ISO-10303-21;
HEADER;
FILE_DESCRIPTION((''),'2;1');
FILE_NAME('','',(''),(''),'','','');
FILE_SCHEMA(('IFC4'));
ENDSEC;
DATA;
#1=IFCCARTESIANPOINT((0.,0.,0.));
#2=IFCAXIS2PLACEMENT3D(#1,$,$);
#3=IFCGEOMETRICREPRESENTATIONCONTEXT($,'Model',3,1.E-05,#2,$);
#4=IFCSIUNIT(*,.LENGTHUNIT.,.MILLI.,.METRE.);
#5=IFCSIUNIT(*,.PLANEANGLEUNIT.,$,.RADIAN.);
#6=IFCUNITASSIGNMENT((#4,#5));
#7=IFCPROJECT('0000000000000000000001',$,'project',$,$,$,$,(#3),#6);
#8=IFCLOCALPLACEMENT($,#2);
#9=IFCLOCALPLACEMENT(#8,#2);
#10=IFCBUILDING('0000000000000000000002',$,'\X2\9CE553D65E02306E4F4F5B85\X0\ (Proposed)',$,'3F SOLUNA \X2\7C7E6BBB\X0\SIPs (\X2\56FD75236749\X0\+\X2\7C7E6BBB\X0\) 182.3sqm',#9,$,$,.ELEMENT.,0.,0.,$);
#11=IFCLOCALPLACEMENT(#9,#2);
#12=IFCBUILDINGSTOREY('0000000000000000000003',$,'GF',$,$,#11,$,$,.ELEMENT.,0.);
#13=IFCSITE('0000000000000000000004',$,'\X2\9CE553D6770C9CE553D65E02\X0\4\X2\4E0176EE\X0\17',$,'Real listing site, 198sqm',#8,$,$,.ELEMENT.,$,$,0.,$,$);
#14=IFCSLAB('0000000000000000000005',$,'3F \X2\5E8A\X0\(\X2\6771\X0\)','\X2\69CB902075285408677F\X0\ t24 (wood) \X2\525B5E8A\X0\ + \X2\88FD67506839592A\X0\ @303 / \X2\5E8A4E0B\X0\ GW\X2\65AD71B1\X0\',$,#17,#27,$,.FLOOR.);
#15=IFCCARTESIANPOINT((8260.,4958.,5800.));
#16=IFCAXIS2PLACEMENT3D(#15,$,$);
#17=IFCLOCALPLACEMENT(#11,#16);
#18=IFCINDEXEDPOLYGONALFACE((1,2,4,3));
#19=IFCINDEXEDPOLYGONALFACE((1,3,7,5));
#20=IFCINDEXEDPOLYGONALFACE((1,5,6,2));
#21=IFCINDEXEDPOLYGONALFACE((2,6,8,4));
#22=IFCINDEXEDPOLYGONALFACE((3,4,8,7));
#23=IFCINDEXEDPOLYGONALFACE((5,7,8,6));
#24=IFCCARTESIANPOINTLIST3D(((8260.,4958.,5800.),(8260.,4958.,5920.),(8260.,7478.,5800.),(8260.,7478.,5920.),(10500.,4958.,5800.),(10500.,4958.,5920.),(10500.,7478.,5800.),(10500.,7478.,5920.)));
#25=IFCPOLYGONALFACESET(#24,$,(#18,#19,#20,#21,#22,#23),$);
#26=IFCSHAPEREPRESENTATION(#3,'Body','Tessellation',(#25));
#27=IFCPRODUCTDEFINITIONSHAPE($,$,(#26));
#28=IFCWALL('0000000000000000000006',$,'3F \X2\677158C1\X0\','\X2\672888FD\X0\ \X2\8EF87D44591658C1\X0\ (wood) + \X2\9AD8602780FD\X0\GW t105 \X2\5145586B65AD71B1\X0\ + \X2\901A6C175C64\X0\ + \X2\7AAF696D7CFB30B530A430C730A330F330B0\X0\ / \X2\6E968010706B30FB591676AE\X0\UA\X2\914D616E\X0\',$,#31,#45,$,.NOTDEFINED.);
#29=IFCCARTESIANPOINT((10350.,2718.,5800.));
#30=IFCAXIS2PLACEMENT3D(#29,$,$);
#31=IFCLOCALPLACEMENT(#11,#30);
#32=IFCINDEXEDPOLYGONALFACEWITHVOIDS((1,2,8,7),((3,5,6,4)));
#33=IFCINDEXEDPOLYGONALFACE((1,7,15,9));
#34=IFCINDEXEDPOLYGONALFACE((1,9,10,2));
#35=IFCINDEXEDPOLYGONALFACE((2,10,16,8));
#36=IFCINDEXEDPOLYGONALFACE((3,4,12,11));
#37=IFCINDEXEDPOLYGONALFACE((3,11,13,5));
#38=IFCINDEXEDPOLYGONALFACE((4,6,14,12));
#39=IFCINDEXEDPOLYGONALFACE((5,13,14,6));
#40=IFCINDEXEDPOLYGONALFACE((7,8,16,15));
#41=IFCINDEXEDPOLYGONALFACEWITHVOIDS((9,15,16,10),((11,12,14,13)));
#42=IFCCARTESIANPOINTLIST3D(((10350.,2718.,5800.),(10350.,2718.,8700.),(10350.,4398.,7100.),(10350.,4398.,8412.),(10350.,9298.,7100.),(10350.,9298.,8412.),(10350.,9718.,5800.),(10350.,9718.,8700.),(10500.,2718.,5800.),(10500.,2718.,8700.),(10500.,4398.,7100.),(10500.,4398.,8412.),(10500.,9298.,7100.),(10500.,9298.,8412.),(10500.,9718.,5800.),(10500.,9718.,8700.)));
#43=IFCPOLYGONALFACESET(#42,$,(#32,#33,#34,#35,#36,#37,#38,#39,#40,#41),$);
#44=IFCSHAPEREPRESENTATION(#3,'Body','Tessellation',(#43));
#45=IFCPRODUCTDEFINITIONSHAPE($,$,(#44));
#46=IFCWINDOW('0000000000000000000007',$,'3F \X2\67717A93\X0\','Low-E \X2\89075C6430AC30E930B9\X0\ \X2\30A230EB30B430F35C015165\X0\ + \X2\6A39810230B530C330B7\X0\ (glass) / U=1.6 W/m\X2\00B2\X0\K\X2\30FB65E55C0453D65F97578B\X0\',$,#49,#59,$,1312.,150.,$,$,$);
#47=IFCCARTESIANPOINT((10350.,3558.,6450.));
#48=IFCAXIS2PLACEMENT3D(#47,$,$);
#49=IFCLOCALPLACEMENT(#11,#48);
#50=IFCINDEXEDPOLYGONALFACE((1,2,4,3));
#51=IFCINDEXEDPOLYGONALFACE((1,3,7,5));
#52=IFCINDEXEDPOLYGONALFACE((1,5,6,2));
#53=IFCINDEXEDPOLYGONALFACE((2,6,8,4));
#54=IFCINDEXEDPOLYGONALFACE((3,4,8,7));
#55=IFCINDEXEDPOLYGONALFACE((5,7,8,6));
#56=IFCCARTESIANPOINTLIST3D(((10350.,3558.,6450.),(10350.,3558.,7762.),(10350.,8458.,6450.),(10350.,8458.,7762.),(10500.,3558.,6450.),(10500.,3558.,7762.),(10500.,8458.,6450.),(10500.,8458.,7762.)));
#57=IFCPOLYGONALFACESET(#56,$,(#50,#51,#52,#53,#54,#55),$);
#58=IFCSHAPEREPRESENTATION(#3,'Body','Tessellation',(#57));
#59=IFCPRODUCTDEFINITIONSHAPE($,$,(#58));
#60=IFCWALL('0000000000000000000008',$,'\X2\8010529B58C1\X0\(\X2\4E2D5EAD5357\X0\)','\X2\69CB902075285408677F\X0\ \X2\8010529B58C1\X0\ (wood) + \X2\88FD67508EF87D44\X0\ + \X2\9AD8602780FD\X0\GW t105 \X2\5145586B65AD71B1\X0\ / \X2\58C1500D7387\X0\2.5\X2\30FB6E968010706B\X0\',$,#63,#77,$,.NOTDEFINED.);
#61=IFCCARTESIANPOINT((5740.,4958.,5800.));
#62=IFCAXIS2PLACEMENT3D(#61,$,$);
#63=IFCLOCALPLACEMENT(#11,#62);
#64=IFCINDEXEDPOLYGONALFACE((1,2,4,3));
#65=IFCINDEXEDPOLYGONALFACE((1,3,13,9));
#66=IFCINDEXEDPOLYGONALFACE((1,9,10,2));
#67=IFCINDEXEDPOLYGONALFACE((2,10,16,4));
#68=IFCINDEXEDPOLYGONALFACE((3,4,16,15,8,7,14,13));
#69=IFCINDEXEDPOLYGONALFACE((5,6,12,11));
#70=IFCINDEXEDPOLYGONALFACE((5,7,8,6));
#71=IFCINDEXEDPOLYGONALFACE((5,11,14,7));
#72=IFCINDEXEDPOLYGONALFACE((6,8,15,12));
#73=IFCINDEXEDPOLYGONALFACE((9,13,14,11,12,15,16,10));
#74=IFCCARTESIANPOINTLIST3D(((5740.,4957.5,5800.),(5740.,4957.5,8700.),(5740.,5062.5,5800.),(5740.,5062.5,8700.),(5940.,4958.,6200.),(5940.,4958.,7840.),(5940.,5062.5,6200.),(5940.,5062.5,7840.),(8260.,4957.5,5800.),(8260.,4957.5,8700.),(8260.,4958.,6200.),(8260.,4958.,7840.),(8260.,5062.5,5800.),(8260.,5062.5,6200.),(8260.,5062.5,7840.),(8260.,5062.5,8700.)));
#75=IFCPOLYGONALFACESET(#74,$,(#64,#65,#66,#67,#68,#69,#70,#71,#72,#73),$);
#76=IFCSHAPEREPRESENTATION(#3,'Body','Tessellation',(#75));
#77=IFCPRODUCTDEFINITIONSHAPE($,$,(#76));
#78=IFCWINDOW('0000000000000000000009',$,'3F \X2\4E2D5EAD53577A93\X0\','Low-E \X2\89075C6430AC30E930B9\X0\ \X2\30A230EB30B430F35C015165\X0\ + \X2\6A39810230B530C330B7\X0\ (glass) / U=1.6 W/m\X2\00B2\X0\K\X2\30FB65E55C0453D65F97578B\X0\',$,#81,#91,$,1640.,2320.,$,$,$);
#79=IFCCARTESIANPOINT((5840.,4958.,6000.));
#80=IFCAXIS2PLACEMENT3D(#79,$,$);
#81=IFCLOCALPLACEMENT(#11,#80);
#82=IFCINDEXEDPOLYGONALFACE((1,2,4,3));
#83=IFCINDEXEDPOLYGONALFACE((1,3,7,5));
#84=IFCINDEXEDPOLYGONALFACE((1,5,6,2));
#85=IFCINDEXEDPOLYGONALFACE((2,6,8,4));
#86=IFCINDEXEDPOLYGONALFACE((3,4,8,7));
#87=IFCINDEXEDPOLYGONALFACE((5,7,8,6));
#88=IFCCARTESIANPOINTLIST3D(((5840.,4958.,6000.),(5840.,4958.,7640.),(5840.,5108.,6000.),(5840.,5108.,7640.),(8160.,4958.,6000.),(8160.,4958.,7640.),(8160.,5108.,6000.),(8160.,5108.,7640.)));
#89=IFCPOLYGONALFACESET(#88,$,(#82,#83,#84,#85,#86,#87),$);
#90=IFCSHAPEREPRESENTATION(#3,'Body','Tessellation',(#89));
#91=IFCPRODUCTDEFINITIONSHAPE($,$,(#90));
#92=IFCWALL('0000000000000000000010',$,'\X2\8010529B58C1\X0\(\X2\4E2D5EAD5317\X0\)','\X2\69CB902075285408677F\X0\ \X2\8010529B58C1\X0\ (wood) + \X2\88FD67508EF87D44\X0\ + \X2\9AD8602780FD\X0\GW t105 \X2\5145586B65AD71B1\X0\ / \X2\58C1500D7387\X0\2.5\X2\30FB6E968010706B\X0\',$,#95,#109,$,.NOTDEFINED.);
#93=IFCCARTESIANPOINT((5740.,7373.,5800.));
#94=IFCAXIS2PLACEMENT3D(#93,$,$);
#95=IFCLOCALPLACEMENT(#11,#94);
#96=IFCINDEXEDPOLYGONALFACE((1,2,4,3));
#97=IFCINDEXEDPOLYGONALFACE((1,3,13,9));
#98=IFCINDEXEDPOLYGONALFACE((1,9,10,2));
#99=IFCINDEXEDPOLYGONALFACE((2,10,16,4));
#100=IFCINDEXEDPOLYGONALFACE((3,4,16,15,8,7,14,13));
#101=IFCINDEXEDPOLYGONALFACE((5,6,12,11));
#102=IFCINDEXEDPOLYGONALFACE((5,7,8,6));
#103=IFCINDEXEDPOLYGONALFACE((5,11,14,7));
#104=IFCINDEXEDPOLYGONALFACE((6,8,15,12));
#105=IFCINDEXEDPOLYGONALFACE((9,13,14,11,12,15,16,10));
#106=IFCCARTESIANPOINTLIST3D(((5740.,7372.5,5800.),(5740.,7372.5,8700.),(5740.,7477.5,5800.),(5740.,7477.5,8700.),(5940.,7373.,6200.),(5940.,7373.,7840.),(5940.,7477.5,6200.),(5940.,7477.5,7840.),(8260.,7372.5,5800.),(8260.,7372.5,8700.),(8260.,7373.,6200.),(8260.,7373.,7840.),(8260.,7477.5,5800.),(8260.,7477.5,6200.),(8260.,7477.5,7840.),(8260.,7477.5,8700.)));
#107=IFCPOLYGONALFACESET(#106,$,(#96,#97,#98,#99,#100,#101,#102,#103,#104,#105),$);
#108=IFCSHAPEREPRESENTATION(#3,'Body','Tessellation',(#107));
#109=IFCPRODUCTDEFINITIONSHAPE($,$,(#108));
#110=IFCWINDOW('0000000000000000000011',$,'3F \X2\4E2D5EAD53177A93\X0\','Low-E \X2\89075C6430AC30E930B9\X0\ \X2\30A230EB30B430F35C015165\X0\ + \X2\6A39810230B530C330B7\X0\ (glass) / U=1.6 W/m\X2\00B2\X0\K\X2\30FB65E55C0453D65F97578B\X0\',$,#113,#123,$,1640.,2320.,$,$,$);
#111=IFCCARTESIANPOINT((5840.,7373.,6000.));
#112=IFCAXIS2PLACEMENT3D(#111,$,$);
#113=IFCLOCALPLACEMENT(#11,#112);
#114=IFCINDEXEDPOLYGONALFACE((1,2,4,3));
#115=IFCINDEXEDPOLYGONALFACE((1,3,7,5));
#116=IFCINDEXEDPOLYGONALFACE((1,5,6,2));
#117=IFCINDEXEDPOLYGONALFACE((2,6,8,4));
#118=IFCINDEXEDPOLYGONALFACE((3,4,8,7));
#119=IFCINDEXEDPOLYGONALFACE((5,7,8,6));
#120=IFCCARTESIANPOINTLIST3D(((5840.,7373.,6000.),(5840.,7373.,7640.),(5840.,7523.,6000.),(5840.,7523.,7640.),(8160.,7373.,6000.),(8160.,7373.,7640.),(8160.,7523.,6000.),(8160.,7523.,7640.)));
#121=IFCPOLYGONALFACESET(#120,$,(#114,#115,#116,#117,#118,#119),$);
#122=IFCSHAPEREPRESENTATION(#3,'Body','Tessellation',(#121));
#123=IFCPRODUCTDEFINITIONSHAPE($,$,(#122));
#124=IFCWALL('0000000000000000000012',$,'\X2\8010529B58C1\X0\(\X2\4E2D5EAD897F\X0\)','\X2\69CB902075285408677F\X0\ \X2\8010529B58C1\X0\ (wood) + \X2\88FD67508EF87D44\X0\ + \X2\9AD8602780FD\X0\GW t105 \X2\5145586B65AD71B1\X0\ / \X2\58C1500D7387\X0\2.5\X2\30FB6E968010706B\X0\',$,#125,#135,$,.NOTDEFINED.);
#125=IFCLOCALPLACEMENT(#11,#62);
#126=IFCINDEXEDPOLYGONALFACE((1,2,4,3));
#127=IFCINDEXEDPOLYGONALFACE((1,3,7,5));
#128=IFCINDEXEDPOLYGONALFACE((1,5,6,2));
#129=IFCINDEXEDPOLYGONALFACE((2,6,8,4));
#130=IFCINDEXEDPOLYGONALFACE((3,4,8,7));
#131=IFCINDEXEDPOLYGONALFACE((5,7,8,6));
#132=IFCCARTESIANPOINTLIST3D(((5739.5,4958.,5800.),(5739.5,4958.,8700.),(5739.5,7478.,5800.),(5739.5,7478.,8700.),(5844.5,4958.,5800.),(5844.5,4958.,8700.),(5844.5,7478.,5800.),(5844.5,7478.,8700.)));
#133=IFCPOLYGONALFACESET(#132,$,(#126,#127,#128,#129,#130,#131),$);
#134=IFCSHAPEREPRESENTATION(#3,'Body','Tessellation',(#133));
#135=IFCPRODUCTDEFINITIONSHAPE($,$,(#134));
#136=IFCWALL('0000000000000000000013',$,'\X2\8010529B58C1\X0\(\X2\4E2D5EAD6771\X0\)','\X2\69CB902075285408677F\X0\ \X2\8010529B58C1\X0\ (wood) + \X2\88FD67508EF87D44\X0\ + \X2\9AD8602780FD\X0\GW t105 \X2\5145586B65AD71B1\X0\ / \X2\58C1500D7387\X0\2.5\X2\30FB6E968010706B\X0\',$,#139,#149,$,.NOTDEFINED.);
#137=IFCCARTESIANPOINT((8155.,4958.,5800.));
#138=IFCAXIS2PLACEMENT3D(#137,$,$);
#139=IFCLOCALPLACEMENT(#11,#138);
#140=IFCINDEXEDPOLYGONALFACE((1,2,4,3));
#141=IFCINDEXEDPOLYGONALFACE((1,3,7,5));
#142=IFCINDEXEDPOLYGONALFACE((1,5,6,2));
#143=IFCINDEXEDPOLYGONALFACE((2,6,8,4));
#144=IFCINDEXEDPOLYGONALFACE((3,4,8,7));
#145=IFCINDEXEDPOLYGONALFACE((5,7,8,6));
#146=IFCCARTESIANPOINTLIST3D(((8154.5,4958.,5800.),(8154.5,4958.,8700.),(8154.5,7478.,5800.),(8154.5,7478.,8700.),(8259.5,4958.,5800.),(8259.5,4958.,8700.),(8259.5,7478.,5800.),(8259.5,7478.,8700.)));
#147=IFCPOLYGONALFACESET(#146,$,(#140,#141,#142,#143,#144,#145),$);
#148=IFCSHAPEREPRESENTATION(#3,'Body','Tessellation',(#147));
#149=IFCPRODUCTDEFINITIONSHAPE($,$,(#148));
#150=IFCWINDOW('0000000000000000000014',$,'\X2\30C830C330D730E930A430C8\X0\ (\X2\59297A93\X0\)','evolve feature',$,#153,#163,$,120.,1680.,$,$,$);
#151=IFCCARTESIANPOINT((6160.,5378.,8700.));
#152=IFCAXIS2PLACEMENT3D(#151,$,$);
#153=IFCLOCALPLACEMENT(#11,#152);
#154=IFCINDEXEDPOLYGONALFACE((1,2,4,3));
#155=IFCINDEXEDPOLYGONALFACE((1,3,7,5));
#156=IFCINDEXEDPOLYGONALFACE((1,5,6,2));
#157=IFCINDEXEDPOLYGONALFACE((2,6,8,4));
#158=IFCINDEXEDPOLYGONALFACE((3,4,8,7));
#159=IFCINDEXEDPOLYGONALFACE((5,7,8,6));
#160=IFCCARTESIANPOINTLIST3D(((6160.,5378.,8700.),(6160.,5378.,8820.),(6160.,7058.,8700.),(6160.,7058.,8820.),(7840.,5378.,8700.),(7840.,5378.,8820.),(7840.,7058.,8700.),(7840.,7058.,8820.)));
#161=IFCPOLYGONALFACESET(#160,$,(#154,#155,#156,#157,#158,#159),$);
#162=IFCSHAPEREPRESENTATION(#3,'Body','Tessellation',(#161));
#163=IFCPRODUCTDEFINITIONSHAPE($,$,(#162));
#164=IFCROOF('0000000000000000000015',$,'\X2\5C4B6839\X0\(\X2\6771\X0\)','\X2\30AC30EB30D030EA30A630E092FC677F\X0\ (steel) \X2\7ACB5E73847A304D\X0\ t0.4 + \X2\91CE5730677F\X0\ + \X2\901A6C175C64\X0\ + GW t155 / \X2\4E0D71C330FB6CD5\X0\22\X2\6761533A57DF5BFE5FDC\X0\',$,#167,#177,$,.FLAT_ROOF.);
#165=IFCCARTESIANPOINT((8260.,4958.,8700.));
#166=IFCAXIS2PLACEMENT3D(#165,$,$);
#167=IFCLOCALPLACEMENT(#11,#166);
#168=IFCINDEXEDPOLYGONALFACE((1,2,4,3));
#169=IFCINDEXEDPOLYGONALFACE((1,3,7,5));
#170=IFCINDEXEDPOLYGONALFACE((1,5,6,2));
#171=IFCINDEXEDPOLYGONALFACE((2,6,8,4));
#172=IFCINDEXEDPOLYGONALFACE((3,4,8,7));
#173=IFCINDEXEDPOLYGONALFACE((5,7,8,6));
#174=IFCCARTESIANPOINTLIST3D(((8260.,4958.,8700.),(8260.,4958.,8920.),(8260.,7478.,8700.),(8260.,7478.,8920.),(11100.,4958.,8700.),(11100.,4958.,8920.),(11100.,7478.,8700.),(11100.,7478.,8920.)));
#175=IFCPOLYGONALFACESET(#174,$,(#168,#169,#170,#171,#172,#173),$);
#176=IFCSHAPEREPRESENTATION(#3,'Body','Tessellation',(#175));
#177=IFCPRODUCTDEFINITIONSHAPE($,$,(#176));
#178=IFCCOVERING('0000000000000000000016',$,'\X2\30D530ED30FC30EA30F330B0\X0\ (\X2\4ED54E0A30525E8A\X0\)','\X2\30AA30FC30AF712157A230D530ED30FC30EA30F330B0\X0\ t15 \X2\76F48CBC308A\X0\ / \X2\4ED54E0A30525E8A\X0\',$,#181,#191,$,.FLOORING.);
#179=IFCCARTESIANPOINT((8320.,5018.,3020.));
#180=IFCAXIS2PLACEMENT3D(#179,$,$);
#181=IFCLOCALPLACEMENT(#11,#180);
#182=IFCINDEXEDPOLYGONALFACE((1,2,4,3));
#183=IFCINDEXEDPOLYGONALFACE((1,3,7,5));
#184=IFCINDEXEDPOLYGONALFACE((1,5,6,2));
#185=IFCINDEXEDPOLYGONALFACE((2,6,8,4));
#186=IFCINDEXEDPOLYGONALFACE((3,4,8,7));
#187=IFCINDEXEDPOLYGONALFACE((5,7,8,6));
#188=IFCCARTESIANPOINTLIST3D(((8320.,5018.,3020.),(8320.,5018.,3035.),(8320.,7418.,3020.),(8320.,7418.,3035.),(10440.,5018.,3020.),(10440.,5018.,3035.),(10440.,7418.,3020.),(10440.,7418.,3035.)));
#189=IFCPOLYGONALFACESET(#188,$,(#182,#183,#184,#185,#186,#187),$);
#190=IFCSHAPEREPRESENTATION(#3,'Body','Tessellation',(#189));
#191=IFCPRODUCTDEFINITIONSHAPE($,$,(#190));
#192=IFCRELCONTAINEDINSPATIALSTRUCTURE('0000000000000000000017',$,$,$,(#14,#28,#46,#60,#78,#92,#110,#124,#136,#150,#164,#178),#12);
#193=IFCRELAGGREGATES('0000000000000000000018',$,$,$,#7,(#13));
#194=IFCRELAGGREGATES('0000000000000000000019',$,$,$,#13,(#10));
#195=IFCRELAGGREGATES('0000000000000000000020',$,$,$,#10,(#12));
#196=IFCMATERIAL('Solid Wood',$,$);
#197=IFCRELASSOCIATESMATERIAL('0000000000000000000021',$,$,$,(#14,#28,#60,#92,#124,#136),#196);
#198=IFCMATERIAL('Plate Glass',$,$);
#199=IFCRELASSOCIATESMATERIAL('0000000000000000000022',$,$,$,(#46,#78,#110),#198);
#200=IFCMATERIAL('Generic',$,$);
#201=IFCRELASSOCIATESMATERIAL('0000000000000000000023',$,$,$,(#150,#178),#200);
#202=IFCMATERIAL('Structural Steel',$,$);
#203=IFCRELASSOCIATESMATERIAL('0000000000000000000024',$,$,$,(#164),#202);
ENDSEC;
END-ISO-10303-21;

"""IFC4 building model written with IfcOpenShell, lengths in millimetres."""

from ifc_helpers import new_model, si_unit, frame, frame_2d, origin, place, context, project, spatial, rectangle, extrude, material, element, fill, save


model = new_model("IFC4")

# Units and contexts
model_context = context("Model", 3, precision=1e-05, world=origin())
ifc_project = project(units=[si_unit("LENGTHUNIT", "METRE", prefix="MILLI"), si_unit("PLANEANGLEUNIT", "RADIAN")], contexts=[model_context])

# Site, building, storey
site_placement = place(None, origin())
site = spatial("IfcSite", under=ifc_project, at=site_placement, Name="鳥取県鳥取市4丁目17", ObjectType="Real listing site, 198sqm", CompositionType="ELEMENT", RefElevation=0.0)
building_placement = place(site_placement, origin())
building = spatial("IfcBuilding", under=site, at=building_placement, Name="鳥取市の住宅 (Proposed)", ObjectType="3F SOLUNA 籾殻SIPs (国産杉+籾殻) 182.3sqm", CompositionType="ELEMENT", ElevationOfRefHeight=0.0, ElevationOfTerrain=0.0)
storey_placement = place(building_placement, origin())
storey = spatial("IfcBuildingStorey", under=building, at=storey_placement, Name="GF", CompositionType="ELEMENT", Elevation=0.0)

# Slab
ifc_material_1 = material(Name="Solid Wood")
slab_placement = place(storey_placement, frame((8260.0, 4958.0, 5800.0)))
element("IfcSlab", 1, at=slab_placement, inside=storey, material=ifc_material_1, Name="3F 床(東)", Description="構造用合板 t24 (wood) 剛床 + 製材根太 @303 / 床下 GW断熱", PredefinedType="FLOOR", context=model_context, shape_type="SweptSolid", body=[
    extrude(rectangle(XDim=2240.0, YDim=2520.0, at=frame_2d((1120.0, 1260.0))), frame((8260.0, 4958.0, 5800.0)), (0.0, 0.0, 1.0), 120.0),
])

# Walls, openings, windows
wall_1_placement = place(storey_placement, frame((10350.0, 2718.0, 5800.0)))
wall_1 = element("IfcWall", 2, at=wall_1_placement, inside=storey, material=ifc_material_1, Name="3F 東壁", Description="木製 軸組外壁 (wood) + 高性能GW t105 充填断熱 + 通気層 + 窯業系サイディング / 準耐火・外皮UA配慮", PredefinedType="NOTDEFINED", context=model_context, shape_type="SweptSolid", body=[
    extrude(rectangle(XDim=150.0, YDim=7000.0, at=frame_2d((75.0, 3500.0))), frame((10350.0, 2718.0, 5800.0)), (0.0, 0.0, 1.0), 2900.0),
])
opening_1_placement = place(storey_placement, frame((10350.0, 3558.0, 6450.0)))
opening_1 = element("IfcOpeningElement", 3, at=opening_1_placement, cuts=wall_1, PredefinedType="NOTDEFINED", context=model_context, shape_type="SweptSolid", body=[
    extrude(rectangle(XDim=150.0, YDim=4900.0, at=frame_2d((75.0, 2450.0))), frame((10350.0, 3558.0, 6450.0)), (0.0, 0.0, 1.0), 1312.0),
])
ifc_material_2 = material(Name="Plate Glass")
window_1_placement = place(storey_placement, frame((10350.0, 3558.0, 6450.0)))
window_1 = element("IfcWindow", 4, at=window_1_placement, inside=storey, material=ifc_material_2, Name="3F 東窓", Description="Low-E 複層ガラス アルゴン封入 + 樹脂サッシ (glass) / U=1.6 W/m²K・日射取得型", OverallHeight=1312.0, OverallWidth=150.0, context=model_context, shape_type="SweptSolid", body=[
    extrude(rectangle(XDim=150.0, YDim=4900.0, at=frame_2d((75.0, 2450.0))), frame((10350.0, 3558.0, 6450.0)), (0.0, 0.0, 1.0), 1312.0),
])
fill(opening_1, window_1)
wall_2_placement = place(storey_placement, frame((5740.0, 4958.0, 5800.0)))
wall_2 = element("IfcWall", 5, at=wall_2_placement, inside=storey, material=ifc_material_1, Name="耐力壁(中庭南)", Description="構造用合板 耐力壁 (wood) + 製材軸組 + 高性能GW t105 充填断熱 / 壁倍率2.5・準耐火", PredefinedType="NOTDEFINED", context=model_context, shape_type="SweptSolid", body=[
    extrude(rectangle(XDim=2520.0, YDim=105.0, at=frame_2d((1260.0, 52.0))), frame((5740.0, 4958.0, 5800.0)), (0.0, 0.0, 1.0), 2900.0),
])
opening_2_placement = place(storey_placement, frame((5840.0, 4958.0, 6000.0)))
opening_2 = element("IfcOpeningElement", 6, at=opening_2_placement, cuts=wall_2, PredefinedType="NOTDEFINED", context=model_context, shape_type="SweptSolid", body=[
    extrude(rectangle(XDim=2320.0, YDim=150.0, at=frame_2d((1160.0, 75.0))), frame((5840.0, 4958.0, 6000.0)), (0.0, 0.0, 1.0), 1640.0),
])
window_2_placement = place(storey_placement, frame((5840.0, 4958.0, 6000.0)))
window_2 = element("IfcWindow", 7, at=window_2_placement, inside=storey, material=ifc_material_2, Name="3F 中庭南窓", Description="Low-E 複層ガラス アルゴン封入 + 樹脂サッシ (glass) / U=1.6 W/m²K・日射取得型", OverallHeight=1640.0, OverallWidth=2320.0, context=model_context, shape_type="SweptSolid", body=[
    extrude(rectangle(XDim=2320.0, YDim=150.0, at=frame_2d((1160.0, 75.0))), frame((5840.0, 4958.0, 6000.0)), (0.0, 0.0, 1.0), 1640.0),
])
fill(opening_2, window_2)
wall_3_placement = place(storey_placement, frame((5740.0, 7373.0, 5800.0)))
wall_3 = element("IfcWall", 8, at=wall_3_placement, inside=storey, material=ifc_material_1, Name="耐力壁(中庭北)", Description="構造用合板 耐力壁 (wood) + 製材軸組 + 高性能GW t105 充填断熱 / 壁倍率2.5・準耐火", PredefinedType="NOTDEFINED", context=model_context, shape_type="SweptSolid", body=[
    extrude(rectangle(XDim=2520.0, YDim=105.0, at=frame_2d((1260.0, 52.0))), frame((5740.0, 7373.0, 5800.0)), (0.0, 0.0, 1.0), 2900.0),
])
opening_3_placement = place(storey_placement, frame((5840.0, 7373.0, 6000.0)))
opening_3 = element("IfcOpeningElement", 9, at=opening_3_placement, cuts=wall_3, PredefinedType="NOTDEFINED", context=model_context, shape_type="SweptSolid", body=[
    extrude(rectangle(XDim=2320.0, YDim=150.0, at=frame_2d((1160.0, 75.0))), frame((5840.0, 7373.0, 6000.0)), (0.0, 0.0, 1.0), 1640.0),
])
window_3_placement = place(storey_placement, frame((5840.0, 7373.0, 6000.0)))
window_3 = element("IfcWindow", 10, at=window_3_placement, inside=storey, material=ifc_material_2, Name="3F 中庭北窓", Description="Low-E 複層ガラス アルゴン封入 + 樹脂サッシ (glass) / U=1.6 W/m²K・日射取得型", OverallHeight=1640.0, OverallWidth=2320.0, context=model_context, shape_type="SweptSolid", body=[
    extrude(rectangle(XDim=2320.0, YDim=150.0, at=frame_2d((1160.0, 75.0))), frame((5840.0, 7373.0, 6000.0)), (0.0, 0.0, 1.0), 1640.0),
])
fill(opening_3, window_3)

# Walls
wall_4_placement = place(storey_placement, frame((5740.0, 4958.0, 5800.0)))
element("IfcWall", 11, at=wall_4_placement, inside=storey, material=ifc_material_1, Name="耐力壁(中庭西)", Description="構造用合板 耐力壁 (wood) + 製材軸組 + 高性能GW t105 充填断熱 / 壁倍率2.5・準耐火", PredefinedType="NOTDEFINED", context=model_context, shape_type="SweptSolid", body=[
    extrude(rectangle(XDim=105.0, YDim=2520.0, at=frame_2d((52.0, 1260.0))), frame((5740.0, 4958.0, 5800.0)), (0.0, 0.0, 1.0), 2900.0),
])
wall_5_placement = place(storey_placement, frame((8155.0, 4958.0, 5800.0)))
element("IfcWall", 12, at=wall_5_placement, inside=storey, material=ifc_material_1, Name="耐力壁(中庭東)", Description="構造用合板 耐力壁 (wood) + 製材軸組 + 高性能GW t105 充填断熱 / 壁倍率2.5・準耐火", PredefinedType="NOTDEFINED", context=model_context, shape_type="SweptSolid", body=[
    extrude(rectangle(XDim=105.0, YDim=2520.0, at=frame_2d((52.0, 1260.0))), frame((8155.0, 4958.0, 5800.0)), (0.0, 0.0, 1.0), 2900.0),
])

# Window
ifc_material_3 = material(Name="Generic")
window_4_placement = place(storey_placement, frame((6160.0, 5378.0, 8700.0)))
element("IfcWindow", 13, at=window_4_placement, inside=storey, material=ifc_material_3, Name="トップライト (天窓)", Description="evolve feature", OverallHeight=120.0, OverallWidth=1680.0, context=model_context, shape_type="SweptSolid", body=[
    extrude(rectangle(XDim=1680.0, YDim=1680.0, at=frame_2d((840.0, 840.0))), frame((6160.0, 5378.0, 8700.0)), (0.0, 0.0, 1.0), 120.0),
])

# Roof
ifc_material_4 = material(Name="Structural Steel")
for number, where, name in (
    (14, (8260.0, 4958.0, 8700.0), "屋根(東)"),
):
    element("IfcRoof", number, at=place(storey_placement, frame(where)), inside=storey, material=ifc_material_4, Name=name, Description="ガルバリウム鋼板 (steel) 立平葺き t0.4 + 野地板 + 通気層 + GW t155 / 不燃・法22条区域対応", PredefinedType="FLAT_ROOF", context=model_context, shape_type="SweptSolid", body=[
        extrude(rectangle(XDim=2840.0, YDim=2520.0, at=frame_2d((1420.0, 1260.0))), frame((8260.0, 4958.0, 8700.0)), (0.0, 0.0, 1.0), 220.0),
    ])

# Covering
covering_1_placement = place(storey_placement, frame((8320.0, 5018.0, 3020.0)))
element("IfcCovering", 15, at=covering_1_placement, inside=storey, material=ifc_material_3, Name="フローリング (仕上げ床)", Description="オーク無垢フローリング t15 直貼り / 仕上げ床", PredefinedType="FLOORING", context=model_context, shape_type="SweptSolid", body=[
    extrude(rectangle(XDim=2120.0, YDim=2400.0, at=frame_2d((1060.0, 1200.0))), frame((8320.0, 5018.0, 3020.0)), (0.0, 0.0, 1.0), 15.0),
])

save(model, "model.ifc")
